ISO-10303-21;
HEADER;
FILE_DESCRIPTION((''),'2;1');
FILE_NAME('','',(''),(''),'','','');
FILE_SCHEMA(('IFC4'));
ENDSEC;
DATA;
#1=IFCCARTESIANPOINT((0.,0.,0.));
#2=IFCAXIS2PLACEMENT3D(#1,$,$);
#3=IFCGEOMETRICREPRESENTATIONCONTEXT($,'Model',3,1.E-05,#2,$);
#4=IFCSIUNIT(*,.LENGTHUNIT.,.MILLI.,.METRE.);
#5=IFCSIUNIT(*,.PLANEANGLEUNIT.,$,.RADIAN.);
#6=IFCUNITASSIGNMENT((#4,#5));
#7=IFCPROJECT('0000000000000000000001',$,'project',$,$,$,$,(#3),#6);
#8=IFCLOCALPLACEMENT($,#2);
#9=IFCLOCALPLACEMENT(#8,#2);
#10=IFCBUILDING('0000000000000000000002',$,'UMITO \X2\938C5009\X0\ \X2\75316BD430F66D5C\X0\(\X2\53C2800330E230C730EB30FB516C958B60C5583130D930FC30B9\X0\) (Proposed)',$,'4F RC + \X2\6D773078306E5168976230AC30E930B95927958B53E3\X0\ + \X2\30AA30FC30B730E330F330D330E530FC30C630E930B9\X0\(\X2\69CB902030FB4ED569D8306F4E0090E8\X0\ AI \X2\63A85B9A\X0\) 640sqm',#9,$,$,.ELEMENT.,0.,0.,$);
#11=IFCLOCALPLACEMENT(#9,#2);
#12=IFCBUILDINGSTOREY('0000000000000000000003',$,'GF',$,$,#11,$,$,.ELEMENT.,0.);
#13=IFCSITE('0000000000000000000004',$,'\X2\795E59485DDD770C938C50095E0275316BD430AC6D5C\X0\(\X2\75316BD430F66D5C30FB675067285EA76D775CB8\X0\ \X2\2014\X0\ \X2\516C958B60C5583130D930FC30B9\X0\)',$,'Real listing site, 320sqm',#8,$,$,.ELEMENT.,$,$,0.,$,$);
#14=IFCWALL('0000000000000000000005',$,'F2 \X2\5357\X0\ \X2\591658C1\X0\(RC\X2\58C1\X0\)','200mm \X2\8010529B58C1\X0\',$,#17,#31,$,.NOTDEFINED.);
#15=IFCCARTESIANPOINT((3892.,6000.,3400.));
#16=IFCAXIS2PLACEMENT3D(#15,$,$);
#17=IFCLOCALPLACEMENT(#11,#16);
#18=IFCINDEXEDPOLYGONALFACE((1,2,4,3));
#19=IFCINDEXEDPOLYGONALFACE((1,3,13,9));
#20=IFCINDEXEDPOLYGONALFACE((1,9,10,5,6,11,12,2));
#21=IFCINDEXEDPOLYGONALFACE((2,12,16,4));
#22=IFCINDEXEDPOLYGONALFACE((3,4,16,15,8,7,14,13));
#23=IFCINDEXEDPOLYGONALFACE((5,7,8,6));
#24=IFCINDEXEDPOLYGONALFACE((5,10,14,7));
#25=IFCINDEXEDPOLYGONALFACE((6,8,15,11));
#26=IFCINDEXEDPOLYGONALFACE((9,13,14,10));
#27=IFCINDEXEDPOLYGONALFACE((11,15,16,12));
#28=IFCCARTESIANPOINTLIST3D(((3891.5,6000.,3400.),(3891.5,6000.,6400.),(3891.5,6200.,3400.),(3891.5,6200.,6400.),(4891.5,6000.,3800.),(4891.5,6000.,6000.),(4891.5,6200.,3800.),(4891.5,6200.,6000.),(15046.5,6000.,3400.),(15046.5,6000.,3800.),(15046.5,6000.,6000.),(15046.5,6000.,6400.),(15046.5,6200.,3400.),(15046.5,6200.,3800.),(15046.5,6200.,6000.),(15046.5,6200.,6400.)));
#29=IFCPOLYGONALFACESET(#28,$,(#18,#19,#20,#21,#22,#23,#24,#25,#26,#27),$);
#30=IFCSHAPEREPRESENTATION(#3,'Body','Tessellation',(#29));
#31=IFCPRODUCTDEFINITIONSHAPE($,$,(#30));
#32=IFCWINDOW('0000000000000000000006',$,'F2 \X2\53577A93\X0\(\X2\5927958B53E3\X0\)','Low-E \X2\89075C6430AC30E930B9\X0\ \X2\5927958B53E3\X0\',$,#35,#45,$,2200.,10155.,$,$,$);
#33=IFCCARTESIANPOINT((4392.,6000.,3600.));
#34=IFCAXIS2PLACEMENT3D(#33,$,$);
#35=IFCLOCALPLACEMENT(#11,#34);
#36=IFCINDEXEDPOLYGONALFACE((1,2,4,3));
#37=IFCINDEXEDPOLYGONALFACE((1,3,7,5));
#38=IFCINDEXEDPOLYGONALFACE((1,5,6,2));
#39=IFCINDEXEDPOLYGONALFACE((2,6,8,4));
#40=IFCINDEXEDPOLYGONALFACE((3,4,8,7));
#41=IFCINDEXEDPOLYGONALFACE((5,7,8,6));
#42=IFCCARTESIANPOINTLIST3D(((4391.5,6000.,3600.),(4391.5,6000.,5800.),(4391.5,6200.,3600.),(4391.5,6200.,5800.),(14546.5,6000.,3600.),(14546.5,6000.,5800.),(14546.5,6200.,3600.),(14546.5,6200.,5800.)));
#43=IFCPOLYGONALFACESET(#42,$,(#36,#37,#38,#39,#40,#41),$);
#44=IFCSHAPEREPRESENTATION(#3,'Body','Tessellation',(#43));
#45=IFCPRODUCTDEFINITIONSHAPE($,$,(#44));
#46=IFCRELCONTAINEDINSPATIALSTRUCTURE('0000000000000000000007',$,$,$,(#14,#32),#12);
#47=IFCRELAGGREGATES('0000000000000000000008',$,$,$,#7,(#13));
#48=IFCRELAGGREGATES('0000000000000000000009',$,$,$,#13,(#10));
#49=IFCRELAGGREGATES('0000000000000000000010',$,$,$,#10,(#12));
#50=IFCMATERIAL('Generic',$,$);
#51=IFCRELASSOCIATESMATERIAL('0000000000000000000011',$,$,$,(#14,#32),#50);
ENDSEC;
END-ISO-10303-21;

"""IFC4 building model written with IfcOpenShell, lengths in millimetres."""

from ifc_helpers import new_model, si_unit, frame, frame_2d, origin, place, context, project, spatial, rectangle, extrude, material, element, fill, save


model = new_model("IFC4")

# Units and contexts
model_context = context("Model", 3, precision=1e-05, world=origin())
ifc_project = project(units=[si_unit("LENGTHUNIT", "METRE", prefix="MILLI"), si_unit("PLANEANGLEUNIT", "RADIAN")], contexts=[model_context])

# Site, building, storey
site_placement = place(None, origin())
site = spatial("IfcSite", under=ifc_project, at=site_placement, Name="神奈川県鎌倉市由比ガ浜(由比ヶ浜・材木座海岸 — 公開情報ベース)", ObjectType="Real listing site, 320sqm", CompositionType="ELEMENT", RefElevation=0.0)
building_placement = place(site_placement, origin())
building = spatial("IfcBuilding", under=site, at=building_placement, Name="UMITO 鎌倉 由比ヶ浜(参考モデル・公開情報ベース) (Proposed)", ObjectType="4F RC + 海への全面ガラス大開口 + オーシャンビューテラス(構造・仕様は一部 AI 推定) 640sqm", CompositionType="ELEMENT", ElevationOfRefHeight=0.0, ElevationOfTerrain=0.0)
storey_placement = place(building_placement, origin())
storey = spatial("IfcBuildingStorey", under=building, at=storey_placement, Name="GF", CompositionType="ELEMENT", Elevation=0.0)

# Shared definitions
ifc_material_1 = material(Name="Generic")

# Wall, opening, window
wall_1_placement = place(storey_placement, frame((3892.0, 6000.0, 3400.0)))
wall_1 = element("IfcWall", 1, at=wall_1_placement, inside=storey, material=ifc_material_1, Name="F2 南 外壁(RC壁)", Description="200mm 耐力壁", PredefinedType="NOTDEFINED", context=model_context, shape_type="SweptSolid", body=[
    extrude(rectangle(XDim=11155.0, YDim=200.0, at=frame_2d((5577.0, 100.0))), frame((3892.0, 6000.0, 3400.0)), (0.0, 0.0, 1.0), 3000.0),
])
opening_1_placement = place(storey_placement, frame((4392.0, 6000.0, 3600.0)))
opening_1 = element("IfcOpeningElement", 2, at=opening_1_placement, cuts=wall_1, PredefinedType="NOTDEFINED", context=model_context, shape_type="SweptSolid", body=[
    extrude(rectangle(XDim=10155.0, YDim=200.0, at=frame_2d((5077.0, 100.0))), frame((4392.0, 6000.0, 3600.0)), (0.0, 0.0, 1.0), 2200.0),
])
window_1_placement = place(storey_placement, frame((4392.0, 6000.0, 3600.0)))
window_1 = element("IfcWindow", 3, at=window_1_placement, inside=storey, material=ifc_material_1, Name="F2 南窓(大開口)", Description="Low-E 複層ガラス 大開口", OverallHeight=2200.0, OverallWidth=10155.0, context=model_context, shape_type="SweptSolid", body=[
    extrude(rectangle(XDim=10155.0, YDim=200.0, at=frame_2d((5077.0, 100.0))), frame((4392.0, 6000.0, 3600.0)), (0.0, 0.0, 1.0), 2200.0),
])
fill(opening_1, window_1)

save(model, "model.ifc")
